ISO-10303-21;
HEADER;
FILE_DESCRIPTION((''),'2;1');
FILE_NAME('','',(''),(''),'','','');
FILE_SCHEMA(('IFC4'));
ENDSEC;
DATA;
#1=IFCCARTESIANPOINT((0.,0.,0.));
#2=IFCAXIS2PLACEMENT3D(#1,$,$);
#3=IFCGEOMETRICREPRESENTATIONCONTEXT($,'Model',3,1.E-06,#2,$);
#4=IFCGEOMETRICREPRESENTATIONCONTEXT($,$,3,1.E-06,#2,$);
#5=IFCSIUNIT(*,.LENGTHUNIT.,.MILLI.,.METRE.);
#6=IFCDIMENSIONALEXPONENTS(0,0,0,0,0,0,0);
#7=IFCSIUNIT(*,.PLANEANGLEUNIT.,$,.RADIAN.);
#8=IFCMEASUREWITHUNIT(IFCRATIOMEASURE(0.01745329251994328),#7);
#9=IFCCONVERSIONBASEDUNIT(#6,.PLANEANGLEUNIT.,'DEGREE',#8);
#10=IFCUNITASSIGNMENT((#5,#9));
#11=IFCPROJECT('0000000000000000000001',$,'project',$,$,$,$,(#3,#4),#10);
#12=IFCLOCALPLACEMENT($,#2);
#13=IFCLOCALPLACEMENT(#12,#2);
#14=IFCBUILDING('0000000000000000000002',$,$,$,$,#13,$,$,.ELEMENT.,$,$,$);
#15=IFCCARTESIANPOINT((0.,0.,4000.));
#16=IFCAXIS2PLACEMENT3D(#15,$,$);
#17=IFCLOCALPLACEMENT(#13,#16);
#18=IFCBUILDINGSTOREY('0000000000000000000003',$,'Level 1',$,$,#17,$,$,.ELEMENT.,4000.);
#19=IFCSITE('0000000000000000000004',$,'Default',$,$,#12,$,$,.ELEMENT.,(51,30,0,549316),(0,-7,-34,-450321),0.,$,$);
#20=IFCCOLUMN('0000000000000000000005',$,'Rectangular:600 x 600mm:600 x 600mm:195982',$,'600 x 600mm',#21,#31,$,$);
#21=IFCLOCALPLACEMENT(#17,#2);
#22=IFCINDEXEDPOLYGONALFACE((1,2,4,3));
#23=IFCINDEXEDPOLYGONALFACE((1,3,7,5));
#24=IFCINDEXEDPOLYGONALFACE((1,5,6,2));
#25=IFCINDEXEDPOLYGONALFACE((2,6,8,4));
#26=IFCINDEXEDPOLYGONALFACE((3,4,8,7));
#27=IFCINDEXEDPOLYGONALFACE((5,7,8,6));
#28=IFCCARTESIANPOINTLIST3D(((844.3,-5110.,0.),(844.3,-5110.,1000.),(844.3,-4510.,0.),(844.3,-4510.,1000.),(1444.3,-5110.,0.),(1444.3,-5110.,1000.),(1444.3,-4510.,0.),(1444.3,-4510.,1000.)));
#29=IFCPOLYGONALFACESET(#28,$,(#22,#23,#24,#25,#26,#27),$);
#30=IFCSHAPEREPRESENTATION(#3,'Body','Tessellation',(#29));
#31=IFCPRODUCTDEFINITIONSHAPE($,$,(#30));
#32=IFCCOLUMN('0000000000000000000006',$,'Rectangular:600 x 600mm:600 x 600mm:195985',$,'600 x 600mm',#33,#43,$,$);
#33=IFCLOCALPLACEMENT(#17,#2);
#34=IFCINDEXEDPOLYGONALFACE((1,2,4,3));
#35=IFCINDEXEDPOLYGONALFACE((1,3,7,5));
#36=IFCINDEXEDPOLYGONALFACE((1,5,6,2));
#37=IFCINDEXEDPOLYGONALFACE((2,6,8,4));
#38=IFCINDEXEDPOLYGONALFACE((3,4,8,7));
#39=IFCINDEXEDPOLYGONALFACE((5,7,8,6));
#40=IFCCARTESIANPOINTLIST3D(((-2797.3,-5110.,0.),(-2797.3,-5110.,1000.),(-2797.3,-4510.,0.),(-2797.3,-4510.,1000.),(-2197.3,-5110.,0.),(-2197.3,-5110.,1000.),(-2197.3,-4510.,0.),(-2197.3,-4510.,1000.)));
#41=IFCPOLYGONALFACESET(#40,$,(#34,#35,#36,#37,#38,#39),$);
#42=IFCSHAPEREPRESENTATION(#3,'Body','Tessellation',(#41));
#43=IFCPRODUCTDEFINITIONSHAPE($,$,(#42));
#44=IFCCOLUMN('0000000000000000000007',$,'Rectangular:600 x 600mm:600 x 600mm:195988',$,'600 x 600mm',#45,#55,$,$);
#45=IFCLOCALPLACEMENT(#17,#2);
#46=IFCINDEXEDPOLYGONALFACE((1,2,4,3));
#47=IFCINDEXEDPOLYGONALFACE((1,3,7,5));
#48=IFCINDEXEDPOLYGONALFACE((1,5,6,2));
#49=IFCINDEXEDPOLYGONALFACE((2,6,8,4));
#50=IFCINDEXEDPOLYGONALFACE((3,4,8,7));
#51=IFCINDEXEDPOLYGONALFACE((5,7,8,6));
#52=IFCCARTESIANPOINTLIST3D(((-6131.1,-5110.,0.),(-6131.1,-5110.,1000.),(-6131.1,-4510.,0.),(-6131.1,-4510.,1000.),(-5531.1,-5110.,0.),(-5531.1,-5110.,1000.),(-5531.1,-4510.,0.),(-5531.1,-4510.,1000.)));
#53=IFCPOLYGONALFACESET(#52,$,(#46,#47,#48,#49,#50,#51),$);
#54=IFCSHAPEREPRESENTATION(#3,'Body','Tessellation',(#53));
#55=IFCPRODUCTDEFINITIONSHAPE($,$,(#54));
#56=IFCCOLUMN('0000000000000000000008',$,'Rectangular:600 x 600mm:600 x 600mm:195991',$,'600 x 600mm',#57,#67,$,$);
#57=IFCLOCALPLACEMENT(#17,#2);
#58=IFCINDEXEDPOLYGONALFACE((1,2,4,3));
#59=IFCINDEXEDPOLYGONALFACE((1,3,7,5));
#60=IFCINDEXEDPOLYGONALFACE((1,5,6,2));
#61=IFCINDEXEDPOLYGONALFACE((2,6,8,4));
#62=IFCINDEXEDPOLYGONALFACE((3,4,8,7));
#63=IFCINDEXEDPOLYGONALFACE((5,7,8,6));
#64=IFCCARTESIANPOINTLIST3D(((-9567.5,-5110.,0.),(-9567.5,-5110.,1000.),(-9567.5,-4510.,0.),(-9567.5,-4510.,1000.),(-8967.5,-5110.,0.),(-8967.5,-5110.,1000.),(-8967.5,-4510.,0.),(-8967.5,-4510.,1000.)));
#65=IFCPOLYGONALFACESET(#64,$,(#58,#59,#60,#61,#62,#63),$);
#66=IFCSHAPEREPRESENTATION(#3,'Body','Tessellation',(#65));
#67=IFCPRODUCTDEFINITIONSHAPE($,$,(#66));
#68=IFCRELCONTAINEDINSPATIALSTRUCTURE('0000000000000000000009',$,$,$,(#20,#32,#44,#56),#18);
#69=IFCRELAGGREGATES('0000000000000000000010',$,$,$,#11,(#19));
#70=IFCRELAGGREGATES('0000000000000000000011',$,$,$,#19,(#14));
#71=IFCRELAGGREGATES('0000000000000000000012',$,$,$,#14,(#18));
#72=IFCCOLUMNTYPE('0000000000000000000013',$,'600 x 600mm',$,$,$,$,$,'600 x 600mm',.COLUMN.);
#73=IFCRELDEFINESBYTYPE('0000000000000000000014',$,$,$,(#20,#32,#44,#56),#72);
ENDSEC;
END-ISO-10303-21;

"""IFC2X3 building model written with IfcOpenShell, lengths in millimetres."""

from ifc_helpers import new_model, entity, si_unit, converted_unit, frame, frame_2d, origin, place, context, project, spatial, rectangle, extrude, source, transform, mapped, type_object, type_shapes, element, save


model = new_model("IFC2X3")

# Units and contexts
model_context = context("Model", 3, precision=1e-06, world=origin())
context_of_model = context(None, 3, precision=1e-06, world=origin())
ifc_project = project(units=[si_unit("LENGTHUNIT", "METRE", prefix="MILLI"), converted_unit("PLANEANGLEUNIT", "DEGREE", entity("IfcRatioMeasure", 0.01745329251994328), si_unit("PLANEANGLEUNIT", "RADIAN"), dimensions=[0, 0, 0, 0, 0, 0, 0])], contexts=[model_context, context_of_model])

# Site, building, storey
site_placement = place(None, origin())
site = spatial("IfcSite", under=ifc_project, at=site_placement, Name="Default", CompositionType="ELEMENT", RefLatitude=(51, 30, 0, 549316), RefLongitude=(0, -7, -34, -450321), RefElevation=0.0)
building_placement = place(site_placement, origin())
building = spatial("IfcBuilding", under=site, at=building_placement, CompositionType="ELEMENT")
storey_placement = place(building_placement, frame((0.0, 0.0, 4000.0)))
storey = spatial("IfcBuildingStorey", under=building, at=storey_placement, Name="Level 1", CompositionType="ELEMENT", Elevation=4000.0)

# Columns
column_type = type_object("IfcColumnType", Name="600 x 600mm", ElementType="600 x 600mm", PredefinedType="COLUMN")
shared_shape = source(origin(), model_context, "Body", "SweptSolid", [
    extrude(rectangle(XDim=600.0, YDim=600.0, at=frame_2d((0.0, 0.0), x_axis=(0.0, -1.0))), origin(), (0.0, 0.0, 1.0), 1000.0),
])
type_shapes(column_type, [shared_shape])
for number, where, name in (
    (1, (1144.3, -4810.0, 0.0), "Rectangular:600 x 600mm:600 x 600mm:195982"),
    (2, (-2497.3, -4810.0, 0.0), "Rectangular:600 x 600mm:600 x 600mm:195985"),
    (3, (-5831.1, -4810.0, 0.0), "Rectangular:600 x 600mm:600 x 600mm:195988"),
    (4, (-9267.5, -4810.0, 0.0), "Rectangular:600 x 600mm:600 x 600mm:195991"),
):
    element("IfcColumn", number, at=place(storey_placement, frame(where)), inside=storey, type_object=column_type, Name=name, ObjectType="600 x 600mm", context=model_context, shape_type="MappedRepresentation", body=[
        mapped(shared_shape, transform((0.0, 0.0, 0.0), scale=1.0)),
    ])

save(model, "model.ifc")
